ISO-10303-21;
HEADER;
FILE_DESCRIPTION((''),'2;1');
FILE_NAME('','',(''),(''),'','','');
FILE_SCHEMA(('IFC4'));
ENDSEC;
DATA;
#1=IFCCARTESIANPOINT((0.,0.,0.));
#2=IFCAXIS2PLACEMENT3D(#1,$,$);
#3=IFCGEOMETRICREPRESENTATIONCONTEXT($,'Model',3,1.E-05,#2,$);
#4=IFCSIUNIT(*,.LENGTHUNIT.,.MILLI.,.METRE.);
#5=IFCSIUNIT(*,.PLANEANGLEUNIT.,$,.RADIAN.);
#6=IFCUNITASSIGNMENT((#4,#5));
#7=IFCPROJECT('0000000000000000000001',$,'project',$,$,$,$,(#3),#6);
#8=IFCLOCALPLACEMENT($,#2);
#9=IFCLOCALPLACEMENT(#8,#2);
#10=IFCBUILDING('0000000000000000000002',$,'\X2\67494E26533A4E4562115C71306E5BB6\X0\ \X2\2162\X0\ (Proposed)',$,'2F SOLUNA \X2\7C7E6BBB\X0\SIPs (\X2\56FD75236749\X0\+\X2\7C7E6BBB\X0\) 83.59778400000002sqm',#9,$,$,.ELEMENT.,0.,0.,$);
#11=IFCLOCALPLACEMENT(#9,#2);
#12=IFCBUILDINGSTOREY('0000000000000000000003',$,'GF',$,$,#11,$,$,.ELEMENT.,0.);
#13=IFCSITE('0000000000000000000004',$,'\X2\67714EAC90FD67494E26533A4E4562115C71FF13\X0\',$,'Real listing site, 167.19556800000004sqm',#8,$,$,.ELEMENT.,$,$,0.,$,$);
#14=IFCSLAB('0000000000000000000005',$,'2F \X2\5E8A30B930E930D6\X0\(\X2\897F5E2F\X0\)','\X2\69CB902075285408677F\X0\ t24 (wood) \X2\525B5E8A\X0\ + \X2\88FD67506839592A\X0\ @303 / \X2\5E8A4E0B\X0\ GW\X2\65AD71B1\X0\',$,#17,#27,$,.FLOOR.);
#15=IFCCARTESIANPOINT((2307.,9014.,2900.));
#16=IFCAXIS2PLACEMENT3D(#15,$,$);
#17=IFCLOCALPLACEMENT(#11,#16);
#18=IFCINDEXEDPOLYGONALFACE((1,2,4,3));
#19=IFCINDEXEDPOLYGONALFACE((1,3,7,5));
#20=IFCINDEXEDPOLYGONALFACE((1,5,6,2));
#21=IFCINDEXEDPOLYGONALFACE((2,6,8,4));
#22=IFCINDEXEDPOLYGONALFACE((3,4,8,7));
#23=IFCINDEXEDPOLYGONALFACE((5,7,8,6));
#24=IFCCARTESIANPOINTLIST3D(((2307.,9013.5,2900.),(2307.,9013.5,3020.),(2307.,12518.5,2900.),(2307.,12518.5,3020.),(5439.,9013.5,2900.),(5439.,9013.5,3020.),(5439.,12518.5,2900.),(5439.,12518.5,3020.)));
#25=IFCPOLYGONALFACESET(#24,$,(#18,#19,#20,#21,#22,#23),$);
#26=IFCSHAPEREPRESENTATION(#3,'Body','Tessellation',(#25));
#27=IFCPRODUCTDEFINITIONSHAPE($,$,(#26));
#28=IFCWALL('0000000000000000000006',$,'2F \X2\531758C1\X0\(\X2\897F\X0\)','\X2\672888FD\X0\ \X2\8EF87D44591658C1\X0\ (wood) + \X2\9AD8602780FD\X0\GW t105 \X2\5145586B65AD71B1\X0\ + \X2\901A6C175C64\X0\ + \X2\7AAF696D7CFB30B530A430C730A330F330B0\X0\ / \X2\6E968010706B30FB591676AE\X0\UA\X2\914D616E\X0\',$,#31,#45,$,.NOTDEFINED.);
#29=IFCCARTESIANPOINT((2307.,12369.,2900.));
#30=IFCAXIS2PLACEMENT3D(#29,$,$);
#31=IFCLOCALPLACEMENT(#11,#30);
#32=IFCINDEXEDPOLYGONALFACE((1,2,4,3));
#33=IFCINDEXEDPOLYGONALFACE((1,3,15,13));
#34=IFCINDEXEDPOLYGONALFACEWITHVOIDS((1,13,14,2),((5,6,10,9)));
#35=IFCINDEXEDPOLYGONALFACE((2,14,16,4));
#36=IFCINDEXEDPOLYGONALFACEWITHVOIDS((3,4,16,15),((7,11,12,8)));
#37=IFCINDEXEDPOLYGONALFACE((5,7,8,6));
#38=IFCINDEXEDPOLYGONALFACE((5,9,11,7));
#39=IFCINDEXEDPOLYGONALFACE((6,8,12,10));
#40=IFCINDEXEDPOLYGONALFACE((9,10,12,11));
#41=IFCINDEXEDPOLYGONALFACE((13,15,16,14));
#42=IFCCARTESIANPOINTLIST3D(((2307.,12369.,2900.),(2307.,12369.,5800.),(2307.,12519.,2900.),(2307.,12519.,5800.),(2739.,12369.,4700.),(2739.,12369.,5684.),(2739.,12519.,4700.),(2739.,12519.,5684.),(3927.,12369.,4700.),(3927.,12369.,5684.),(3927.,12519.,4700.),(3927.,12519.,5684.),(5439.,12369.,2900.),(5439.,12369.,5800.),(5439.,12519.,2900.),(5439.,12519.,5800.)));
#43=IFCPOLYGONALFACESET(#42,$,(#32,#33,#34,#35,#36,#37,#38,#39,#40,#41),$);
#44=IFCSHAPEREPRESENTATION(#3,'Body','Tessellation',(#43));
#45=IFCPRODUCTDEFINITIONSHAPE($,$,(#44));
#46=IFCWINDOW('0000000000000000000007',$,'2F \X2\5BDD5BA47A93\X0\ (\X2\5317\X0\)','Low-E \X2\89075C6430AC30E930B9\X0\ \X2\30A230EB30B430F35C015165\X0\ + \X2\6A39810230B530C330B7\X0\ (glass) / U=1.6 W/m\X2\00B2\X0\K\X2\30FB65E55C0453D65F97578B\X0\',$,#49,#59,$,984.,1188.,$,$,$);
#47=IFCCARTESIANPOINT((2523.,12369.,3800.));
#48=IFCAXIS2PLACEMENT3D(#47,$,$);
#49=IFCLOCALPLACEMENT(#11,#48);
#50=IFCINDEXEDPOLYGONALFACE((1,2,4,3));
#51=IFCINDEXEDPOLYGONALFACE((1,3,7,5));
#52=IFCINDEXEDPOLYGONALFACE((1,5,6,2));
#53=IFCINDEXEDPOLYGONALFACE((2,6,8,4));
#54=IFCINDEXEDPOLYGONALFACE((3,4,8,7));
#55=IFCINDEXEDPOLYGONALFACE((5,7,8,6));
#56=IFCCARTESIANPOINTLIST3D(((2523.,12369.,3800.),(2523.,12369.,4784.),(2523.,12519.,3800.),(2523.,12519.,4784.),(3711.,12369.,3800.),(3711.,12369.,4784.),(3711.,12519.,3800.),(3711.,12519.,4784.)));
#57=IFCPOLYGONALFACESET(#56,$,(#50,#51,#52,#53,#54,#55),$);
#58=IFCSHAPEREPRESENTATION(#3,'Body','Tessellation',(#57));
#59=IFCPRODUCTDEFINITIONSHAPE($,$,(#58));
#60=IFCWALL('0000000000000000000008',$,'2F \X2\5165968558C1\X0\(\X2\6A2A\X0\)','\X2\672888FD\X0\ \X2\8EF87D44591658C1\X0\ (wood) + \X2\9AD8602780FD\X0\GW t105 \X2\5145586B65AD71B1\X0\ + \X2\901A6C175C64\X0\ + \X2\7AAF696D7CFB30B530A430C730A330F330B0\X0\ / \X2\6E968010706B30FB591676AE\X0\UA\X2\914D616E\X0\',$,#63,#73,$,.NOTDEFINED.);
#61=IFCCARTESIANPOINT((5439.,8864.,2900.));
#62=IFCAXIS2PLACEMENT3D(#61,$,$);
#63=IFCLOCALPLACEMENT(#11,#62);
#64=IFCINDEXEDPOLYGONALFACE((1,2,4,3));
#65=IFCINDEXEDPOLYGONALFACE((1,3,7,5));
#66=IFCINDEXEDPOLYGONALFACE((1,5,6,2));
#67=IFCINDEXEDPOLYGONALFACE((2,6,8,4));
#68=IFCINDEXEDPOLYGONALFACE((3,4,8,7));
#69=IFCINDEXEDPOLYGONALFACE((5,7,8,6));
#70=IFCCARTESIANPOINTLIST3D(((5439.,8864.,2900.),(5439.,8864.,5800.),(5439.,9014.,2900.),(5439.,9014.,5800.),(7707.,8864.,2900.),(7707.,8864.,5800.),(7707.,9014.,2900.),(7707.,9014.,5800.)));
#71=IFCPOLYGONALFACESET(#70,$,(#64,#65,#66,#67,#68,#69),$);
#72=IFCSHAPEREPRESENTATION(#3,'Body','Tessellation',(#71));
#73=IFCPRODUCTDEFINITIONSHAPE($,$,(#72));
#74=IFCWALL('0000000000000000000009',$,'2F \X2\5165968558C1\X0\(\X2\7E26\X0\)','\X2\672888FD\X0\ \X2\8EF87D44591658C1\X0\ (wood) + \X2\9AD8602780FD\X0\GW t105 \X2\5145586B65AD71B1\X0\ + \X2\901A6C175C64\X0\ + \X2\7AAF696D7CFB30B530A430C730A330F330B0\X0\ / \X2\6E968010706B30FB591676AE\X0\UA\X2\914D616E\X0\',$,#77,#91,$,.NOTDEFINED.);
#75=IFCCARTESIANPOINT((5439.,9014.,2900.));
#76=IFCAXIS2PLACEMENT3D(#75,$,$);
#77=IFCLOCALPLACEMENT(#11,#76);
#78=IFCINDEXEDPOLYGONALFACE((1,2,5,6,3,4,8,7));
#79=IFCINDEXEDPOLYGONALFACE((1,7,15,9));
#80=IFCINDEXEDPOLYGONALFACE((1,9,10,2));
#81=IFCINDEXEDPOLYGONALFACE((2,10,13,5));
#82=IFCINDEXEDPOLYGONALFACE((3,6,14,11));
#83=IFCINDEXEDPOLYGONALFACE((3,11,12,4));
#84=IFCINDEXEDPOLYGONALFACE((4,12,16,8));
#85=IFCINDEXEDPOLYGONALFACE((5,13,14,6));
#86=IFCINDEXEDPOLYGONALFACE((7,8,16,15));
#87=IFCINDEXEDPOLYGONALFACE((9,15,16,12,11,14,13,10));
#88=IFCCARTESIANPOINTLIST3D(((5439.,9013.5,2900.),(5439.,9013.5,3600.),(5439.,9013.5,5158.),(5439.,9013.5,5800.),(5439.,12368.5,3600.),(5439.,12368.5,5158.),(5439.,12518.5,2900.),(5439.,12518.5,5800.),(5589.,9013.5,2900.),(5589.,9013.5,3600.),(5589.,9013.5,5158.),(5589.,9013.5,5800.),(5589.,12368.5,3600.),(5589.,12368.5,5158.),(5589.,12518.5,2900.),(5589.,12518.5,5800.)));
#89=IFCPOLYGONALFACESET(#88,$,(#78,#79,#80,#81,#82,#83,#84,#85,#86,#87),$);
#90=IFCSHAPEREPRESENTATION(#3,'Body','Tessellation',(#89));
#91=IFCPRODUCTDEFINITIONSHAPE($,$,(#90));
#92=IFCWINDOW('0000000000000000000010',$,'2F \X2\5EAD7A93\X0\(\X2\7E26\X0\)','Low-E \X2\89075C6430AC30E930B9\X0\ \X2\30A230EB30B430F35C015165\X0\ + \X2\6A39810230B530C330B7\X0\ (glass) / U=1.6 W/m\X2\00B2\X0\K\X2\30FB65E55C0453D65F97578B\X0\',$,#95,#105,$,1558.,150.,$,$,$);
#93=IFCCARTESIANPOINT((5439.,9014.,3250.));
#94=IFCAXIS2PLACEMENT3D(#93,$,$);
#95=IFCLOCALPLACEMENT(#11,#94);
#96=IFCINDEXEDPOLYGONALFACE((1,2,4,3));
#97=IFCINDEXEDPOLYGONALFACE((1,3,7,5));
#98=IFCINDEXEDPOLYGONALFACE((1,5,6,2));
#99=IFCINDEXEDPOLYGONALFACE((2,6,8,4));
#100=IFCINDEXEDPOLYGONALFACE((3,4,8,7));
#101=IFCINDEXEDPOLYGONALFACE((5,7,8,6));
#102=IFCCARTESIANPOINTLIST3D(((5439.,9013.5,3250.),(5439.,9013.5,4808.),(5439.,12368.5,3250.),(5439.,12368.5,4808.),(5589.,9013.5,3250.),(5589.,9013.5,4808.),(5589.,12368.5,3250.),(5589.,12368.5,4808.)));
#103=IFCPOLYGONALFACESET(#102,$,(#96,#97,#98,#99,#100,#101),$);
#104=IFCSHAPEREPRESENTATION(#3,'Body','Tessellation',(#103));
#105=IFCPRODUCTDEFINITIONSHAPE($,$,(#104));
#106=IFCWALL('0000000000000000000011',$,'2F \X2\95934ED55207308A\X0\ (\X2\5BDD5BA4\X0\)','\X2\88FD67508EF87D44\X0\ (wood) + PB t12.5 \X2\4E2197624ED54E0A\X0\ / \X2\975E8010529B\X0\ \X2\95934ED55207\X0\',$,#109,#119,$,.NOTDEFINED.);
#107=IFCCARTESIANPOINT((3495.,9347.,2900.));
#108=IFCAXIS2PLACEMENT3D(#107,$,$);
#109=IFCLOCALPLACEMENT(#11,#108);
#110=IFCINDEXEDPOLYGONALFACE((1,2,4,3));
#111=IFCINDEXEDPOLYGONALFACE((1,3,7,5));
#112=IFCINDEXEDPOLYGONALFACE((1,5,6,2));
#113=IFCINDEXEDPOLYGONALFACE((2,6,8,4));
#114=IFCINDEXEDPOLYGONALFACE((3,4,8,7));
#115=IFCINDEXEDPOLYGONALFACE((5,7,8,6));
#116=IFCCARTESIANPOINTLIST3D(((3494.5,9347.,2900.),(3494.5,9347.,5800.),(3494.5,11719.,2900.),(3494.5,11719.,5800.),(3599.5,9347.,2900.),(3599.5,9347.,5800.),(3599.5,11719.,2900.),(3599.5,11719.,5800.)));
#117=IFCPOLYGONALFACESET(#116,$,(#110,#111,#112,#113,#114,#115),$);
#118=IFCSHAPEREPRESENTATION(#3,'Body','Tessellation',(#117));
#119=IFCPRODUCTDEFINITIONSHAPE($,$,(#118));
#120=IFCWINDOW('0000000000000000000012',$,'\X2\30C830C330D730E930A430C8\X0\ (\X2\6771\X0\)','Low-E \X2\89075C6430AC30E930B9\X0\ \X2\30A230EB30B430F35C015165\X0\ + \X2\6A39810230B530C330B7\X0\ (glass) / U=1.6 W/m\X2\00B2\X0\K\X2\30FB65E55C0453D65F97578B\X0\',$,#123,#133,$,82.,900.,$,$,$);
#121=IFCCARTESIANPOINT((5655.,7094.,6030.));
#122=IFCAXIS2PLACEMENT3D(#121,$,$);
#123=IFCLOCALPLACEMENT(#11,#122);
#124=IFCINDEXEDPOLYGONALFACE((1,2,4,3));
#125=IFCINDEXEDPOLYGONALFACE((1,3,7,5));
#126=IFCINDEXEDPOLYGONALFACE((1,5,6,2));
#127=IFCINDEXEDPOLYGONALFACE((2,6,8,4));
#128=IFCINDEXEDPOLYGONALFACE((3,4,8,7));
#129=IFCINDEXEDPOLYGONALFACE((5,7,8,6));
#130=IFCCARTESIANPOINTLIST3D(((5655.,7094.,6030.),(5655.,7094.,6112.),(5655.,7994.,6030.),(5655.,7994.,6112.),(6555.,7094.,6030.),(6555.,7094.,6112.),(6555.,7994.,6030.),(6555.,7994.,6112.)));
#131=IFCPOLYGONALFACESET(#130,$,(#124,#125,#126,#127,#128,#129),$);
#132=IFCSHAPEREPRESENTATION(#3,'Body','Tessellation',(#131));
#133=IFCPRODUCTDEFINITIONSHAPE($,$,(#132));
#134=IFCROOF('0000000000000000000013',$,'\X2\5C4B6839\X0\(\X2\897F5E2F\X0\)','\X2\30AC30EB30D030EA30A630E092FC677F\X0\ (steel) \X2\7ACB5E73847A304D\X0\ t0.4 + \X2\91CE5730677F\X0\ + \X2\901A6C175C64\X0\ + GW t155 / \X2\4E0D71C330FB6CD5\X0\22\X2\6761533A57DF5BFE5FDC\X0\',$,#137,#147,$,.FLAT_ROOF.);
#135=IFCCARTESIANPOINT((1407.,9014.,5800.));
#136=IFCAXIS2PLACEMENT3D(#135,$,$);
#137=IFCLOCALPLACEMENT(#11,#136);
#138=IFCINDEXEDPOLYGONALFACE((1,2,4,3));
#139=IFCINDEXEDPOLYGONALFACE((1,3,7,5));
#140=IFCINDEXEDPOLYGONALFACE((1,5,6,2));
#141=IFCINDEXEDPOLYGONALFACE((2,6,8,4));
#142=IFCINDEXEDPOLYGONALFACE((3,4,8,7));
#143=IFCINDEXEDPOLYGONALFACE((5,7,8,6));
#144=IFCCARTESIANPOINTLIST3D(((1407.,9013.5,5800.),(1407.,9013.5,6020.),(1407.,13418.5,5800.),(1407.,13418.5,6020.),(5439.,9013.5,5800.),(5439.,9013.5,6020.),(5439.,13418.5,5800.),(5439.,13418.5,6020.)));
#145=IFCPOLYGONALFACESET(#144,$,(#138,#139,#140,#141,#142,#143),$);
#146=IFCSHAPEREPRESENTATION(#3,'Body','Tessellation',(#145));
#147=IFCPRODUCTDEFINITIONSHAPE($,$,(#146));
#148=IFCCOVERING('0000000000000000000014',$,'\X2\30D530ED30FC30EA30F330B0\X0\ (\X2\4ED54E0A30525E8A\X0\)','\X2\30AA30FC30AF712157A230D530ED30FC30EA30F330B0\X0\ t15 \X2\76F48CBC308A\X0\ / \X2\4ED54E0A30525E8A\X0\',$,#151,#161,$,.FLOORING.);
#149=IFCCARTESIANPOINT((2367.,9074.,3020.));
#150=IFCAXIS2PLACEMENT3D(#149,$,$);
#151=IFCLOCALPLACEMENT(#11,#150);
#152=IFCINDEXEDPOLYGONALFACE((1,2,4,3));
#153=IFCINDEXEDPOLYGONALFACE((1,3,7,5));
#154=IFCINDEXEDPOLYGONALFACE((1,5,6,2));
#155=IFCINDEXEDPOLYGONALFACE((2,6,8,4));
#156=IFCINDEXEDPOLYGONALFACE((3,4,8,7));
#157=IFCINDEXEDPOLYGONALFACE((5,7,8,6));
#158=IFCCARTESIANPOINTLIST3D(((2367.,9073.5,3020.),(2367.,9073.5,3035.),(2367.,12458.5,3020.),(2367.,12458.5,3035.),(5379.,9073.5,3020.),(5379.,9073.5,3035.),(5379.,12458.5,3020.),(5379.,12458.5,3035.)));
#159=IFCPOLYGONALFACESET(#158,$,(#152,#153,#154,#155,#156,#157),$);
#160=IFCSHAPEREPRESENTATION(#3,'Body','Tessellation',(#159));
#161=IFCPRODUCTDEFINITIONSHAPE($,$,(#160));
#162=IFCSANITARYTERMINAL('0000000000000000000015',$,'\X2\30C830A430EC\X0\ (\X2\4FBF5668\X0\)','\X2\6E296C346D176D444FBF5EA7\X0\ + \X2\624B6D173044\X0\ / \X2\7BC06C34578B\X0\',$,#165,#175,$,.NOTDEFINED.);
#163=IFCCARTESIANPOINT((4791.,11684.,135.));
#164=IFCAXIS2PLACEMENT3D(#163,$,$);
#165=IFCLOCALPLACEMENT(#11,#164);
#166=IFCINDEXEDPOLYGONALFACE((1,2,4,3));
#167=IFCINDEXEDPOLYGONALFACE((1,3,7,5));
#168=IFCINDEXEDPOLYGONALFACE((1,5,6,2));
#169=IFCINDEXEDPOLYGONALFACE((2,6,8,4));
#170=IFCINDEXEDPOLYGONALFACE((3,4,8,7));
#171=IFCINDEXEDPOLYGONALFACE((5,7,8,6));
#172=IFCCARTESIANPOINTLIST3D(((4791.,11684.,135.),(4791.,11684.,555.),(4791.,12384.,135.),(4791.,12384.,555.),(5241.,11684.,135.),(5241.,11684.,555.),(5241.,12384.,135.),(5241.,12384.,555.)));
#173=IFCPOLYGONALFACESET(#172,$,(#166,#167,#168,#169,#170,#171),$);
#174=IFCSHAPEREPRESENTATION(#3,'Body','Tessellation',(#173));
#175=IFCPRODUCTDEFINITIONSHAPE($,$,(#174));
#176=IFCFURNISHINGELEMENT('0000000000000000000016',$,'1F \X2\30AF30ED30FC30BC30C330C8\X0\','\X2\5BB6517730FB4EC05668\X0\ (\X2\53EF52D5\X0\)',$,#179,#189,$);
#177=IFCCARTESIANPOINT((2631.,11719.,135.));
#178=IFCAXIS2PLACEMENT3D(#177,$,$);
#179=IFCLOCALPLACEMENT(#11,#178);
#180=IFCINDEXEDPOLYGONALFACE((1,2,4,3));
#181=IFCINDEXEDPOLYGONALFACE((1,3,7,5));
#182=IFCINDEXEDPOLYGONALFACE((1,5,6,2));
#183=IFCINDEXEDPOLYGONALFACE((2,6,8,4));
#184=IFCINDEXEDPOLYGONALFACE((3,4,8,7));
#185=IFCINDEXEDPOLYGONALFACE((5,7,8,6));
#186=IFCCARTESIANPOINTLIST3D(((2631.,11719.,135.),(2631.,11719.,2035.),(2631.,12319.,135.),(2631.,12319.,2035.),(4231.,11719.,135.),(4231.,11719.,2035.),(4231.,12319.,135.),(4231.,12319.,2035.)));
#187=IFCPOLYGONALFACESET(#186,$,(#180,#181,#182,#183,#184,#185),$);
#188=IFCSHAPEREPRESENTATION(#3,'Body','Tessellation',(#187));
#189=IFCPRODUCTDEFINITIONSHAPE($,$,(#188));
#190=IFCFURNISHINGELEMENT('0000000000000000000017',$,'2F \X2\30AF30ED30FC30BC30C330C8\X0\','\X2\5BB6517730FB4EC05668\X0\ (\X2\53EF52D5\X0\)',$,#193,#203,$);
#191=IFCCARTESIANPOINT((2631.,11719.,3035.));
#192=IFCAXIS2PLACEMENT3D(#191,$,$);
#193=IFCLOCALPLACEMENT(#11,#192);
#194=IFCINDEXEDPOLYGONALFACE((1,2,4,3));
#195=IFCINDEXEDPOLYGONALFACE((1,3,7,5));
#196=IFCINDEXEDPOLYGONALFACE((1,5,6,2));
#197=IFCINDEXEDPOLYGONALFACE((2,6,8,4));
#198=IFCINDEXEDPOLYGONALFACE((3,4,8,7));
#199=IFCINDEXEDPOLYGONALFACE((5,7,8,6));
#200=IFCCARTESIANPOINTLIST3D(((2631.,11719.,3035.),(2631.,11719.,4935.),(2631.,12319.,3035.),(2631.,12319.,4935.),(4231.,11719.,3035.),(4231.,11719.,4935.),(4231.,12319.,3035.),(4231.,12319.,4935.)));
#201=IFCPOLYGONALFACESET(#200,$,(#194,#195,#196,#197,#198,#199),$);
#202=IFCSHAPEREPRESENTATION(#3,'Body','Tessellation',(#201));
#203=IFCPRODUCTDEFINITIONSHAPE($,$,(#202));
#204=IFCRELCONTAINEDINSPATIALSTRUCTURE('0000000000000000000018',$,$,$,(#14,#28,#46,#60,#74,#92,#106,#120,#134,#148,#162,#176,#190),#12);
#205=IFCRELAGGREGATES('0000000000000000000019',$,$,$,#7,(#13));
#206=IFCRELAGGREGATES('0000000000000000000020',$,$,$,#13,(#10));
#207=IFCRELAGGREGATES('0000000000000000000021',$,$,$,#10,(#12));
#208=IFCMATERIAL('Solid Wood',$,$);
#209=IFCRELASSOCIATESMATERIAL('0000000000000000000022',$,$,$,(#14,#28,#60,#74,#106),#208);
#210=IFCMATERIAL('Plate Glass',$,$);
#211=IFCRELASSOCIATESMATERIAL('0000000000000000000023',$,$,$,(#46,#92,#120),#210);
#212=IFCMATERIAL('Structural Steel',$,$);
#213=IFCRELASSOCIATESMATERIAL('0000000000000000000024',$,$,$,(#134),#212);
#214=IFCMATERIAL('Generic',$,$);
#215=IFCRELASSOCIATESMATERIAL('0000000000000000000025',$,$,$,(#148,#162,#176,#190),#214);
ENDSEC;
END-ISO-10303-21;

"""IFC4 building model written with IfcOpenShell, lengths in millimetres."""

from ifc_helpers import new_model, si_unit, frame, frame_2d, origin, place, context, project, spatial, rectangle, extrude, material, element, fill, save


model = new_model("IFC4")

# Units and contexts
model_context = context("Model", 3, precision=1e-05, world=origin())
ifc_project = project(units=[si_unit("LENGTHUNIT", "METRE", prefix="MILLI"), si_unit("PLANEANGLEUNIT", "RADIAN")], contexts=[model_context])

# Site, building, storey
site_placement = place(None, origin())
site = spatial("IfcSite", under=ifc_project, at=site_placement, Name="東京都杉並区久我山３", ObjectType="Real listing site, 167.19556800000004sqm", CompositionType="ELEMENT", RefElevation=0.0)
building_placement = place(site_placement, origin())
building = spatial("IfcBuilding", under=site, at=building_placement, Name="杉並区久我山の家 Ⅲ (Proposed)", ObjectType="2F SOLUNA 籾殻SIPs (国産杉+籾殻) 83.59778400000002sqm", CompositionType="ELEMENT", ElevationOfRefHeight=0.0, ElevationOfTerrain=0.0)
storey_placement = place(building_placement, origin())
storey = spatial("IfcBuildingStorey", under=building, at=storey_placement, Name="GF", CompositionType="ELEMENT", Elevation=0.0)

# Slab
ifc_material_1 = material(Name="Solid Wood")
slab_placement = place(storey_placement, frame((2307.0, 9014.0, 2900.0)))
element("IfcSlab", 1, at=slab_placement, inside=storey, material=ifc_material_1, Name="2F 床スラブ(西帯)", Description="構造用合板 t24 (wood) 剛床 + 製材根太 @303 / 床下 GW断熱", PredefinedType="FLOOR", context=model_context, shape_type="SweptSolid", body=[
    extrude(rectangle(XDim=3132.0, YDim=3505.0, at=frame_2d((1566.0, 1752.0))), frame((2307.0, 9014.0, 2900.0)), (0.0, 0.0, 1.0), 120.0),
])

# Wall, opening, window
wall_1_placement = place(storey_placement, frame((2307.0, 12369.0, 2900.0)))
wall_1 = element("IfcWall", 2, at=wall_1_placement, inside=storey, material=ifc_material_1, Name="2F 北壁(西)", Description="木製 軸組外壁 (wood) + 高性能GW t105 充填断熱 + 通気層 + 窯業系サイディング / 準耐火・外皮UA配慮", PredefinedType="NOTDEFINED", context=model_context, shape_type="SweptSolid", body=[
    extrude(rectangle(XDim=3132.0, YDim=150.0, at=frame_2d((1566.0, 75.0))), frame((2307.0, 12369.0, 2900.0)), (0.0, 0.0, 1.0), 2900.0),
])
opening_1_placement = place(storey_placement, frame((2523.0, 12369.0, 3800.0)))
opening_1 = element("IfcOpeningElement", 3, at=opening_1_placement, cuts=wall_1, PredefinedType="NOTDEFINED", context=model_context, shape_type="SweptSolid", body=[
    extrude(rectangle(XDim=1188.0, YDim=150.0, at=frame_2d((594.0, 75.0))), frame((2523.0, 12369.0, 3800.0)), (0.0, 0.0, 1.0), 984.0),
])
ifc_material_2 = material(Name="Plate Glass")
window_1_placement = place(storey_placement, frame((2523.0, 12369.0, 3800.0)))
window_1 = element("IfcWindow", 4, at=window_1_placement, inside=storey, material=ifc_material_2, Name="2F 寝室窓 (北)", Description="Low-E 複層ガラス アルゴン封入 + 樹脂サッシ (glass) / U=1.6 W/m²K・日射取得型", OverallHeight=984.0, OverallWidth=1188.0, context=model_context, shape_type="SweptSolid", body=[
    extrude(rectangle(XDim=1188.0, YDim=150.0, at=frame_2d((594.0, 75.0))), frame((2523.0, 12369.0, 3800.0)), (0.0, 0.0, 1.0), 984.0),
])
fill(opening_1, window_1)

# Wall
wall_2_placement = place(storey_placement, frame((5439.0, 8864.0, 2900.0)))
element("IfcWall", 5, at=wall_2_placement, inside=storey, material=ifc_material_1, Name="2F 入隅壁(横)", Description="木製 軸組外壁 (wood) + 高性能GW t105 充填断熱 + 通気層 + 窯業系サイディング / 準耐火・外皮UA配慮", PredefinedType="NOTDEFINED", context=model_context, shape_type="SweptSolid", body=[
    extrude(rectangle(XDim=2268.0, YDim=150.0, at=frame_2d((1134.0, 75.0))), frame((5439.0, 8864.0, 2900.0)), (0.0, 0.0, 1.0), 2900.0),
])

# Wall, opening, window
wall_3_placement = place(storey_placement, frame((5439.0, 9014.0, 2900.0)))
wall_3 = element("IfcWall", 6, at=wall_3_placement, inside=storey, material=ifc_material_1, Name="2F 入隅壁(縦)", Description="木製 軸組外壁 (wood) + 高性能GW t105 充填断熱 + 通気層 + 窯業系サイディング / 準耐火・外皮UA配慮", PredefinedType="NOTDEFINED", context=model_context, shape_type="SweptSolid", body=[
    extrude(rectangle(XDim=150.0, YDim=3505.0, at=frame_2d((75.0, 1752.0))), frame((5439.0, 9014.0, 2900.0)), (0.0, 0.0, 1.0), 2900.0),
])
opening_2_placement = place(storey_placement, frame((5439.0, 9014.0, 3250.0)))
opening_2 = element("IfcOpeningElement", 7, at=opening_2_placement, cuts=wall_3, PredefinedType="NOTDEFINED", context=model_context, shape_type="SweptSolid", body=[
    extrude(rectangle(XDim=150.0, YDim=3355.0, at=frame_2d((75.0, 1677.0))), frame((5439.0, 9014.0, 3250.0)), (0.0, 0.0, 1.0), 1558.0),
])
window_2_placement = place(storey_placement, frame((5439.0, 9014.0, 3250.0)))
window_2 = element("IfcWindow", 8, at=window_2_placement, inside=storey, material=ifc_material_2, Name="2F 庭窓(縦)", Description="Low-E 複層ガラス アルゴン封入 + 樹脂サッシ (glass) / U=1.6 W/m²K・日射取得型", OverallHeight=1558.0, OverallWidth=150.0, context=model_context, shape_type="SweptSolid", body=[
    extrude(rectangle(XDim=150.0, YDim=3355.0, at=frame_2d((75.0, 1677.0))), frame((5439.0, 9014.0, 3250.0)), (0.0, 0.0, 1.0), 1558.0),
])
fill(opening_2, window_2)

# Wall
wall_4_placement = place(storey_placement, frame((3495.0, 9347.0, 2900.0)))
element("IfcWall", 9, at=wall_4_placement, inside=storey, material=ifc_material_1, Name="2F 間仕切り (寝室)", Description="製材軸組 (wood) + PB t12.5 両面仕上 / 非耐力 間仕切", PredefinedType="NOTDEFINED", context=model_context, shape_type="SweptSolid", body=[
    extrude(rectangle(XDim=105.0, YDim=2372.0, at=frame_2d((52.0, 1186.0))), frame((3495.0, 9347.0, 2900.0)), (0.0, 0.0, 1.0), 2900.0),
])

# Window
window_3_placement = place(storey_placement, frame((5655.0, 7094.0, 6030.0)))
element("IfcWindow", 10, at=window_3_placement, inside=storey, material=ifc_material_2, Name="トップライト (東)", Description="Low-E 複層ガラス アルゴン封入 + 樹脂サッシ (glass) / U=1.6 W/m²K・日射取得型", OverallHeight=82.0, OverallWidth=900.0, context=model_context, shape_type="SweptSolid", body=[
    extrude(rectangle(XDim=900.0, YDim=900.0, at=frame_2d((450.0, 450.0))), frame((5655.0, 7094.0, 6030.0)), (0.0, 0.0, 1.0), 82.0),
])

# Roof
ifc_material_3 = material(Name="Structural Steel")
for number, where, name in (
    (11, (1407.0, 9014.0, 5800.0), "屋根(西帯)"),
):
    element("IfcRoof", number, at=place(storey_placement, frame(where)), inside=storey, material=ifc_material_3, Name=name, Description="ガルバリウム鋼板 (steel) 立平葺き t0.4 + 野地板 + 通気層 + GW t155 / 不燃・法22条区域対応", PredefinedType="FLAT_ROOF", context=model_context, shape_type="SweptSolid", body=[
        extrude(rectangle(XDim=4032.0, YDim=4405.0, at=frame_2d((2016.0, 2202.0))), frame((1407.0, 9014.0, 5800.0)), (0.0, 0.0, 1.0), 220.0),
    ])

# Covering
ifc_material_4 = material(Name="Generic")
covering_placement = place(storey_placement, frame((2367.0, 9074.0, 3020.0)))
element("IfcCovering", 12, at=covering_placement, inside=storey, material=ifc_material_4, Name="フローリング (仕上げ床)", Description="オーク無垢フローリング t15 直貼り / 仕上げ床", PredefinedType="FLOORING", context=model_context, shape_type="SweptSolid", body=[
    extrude(rectangle(XDim=3012.0, YDim=3385.0, at=frame_2d((1506.0, 1692.0))), frame((2367.0, 9074.0, 3020.0)), (0.0, 0.0, 1.0), 15.0),
])

# Sanitary terminal
sanitary_terminal_placement = place(storey_placement, frame((4791.0, 11684.0, 135.0)))
element("IfcSanitaryTerminal", 13, at=sanitary_terminal_placement, inside=storey, material=ifc_material_4, Name="トイレ (便器)", Description="温水洗浄便座 + 手洗い / 節水型", PredefinedType="NOTDEFINED", context=model_context, shape_type="SweptSolid", body=[
    extrude(rectangle(XDim=450.0, YDim=700.0, at=frame_2d((225.0, 350.0))), frame((4791.0, 11684.0, 135.0)), (0.0, 0.0, 1.0), 420.0),
])

# Furnishing elements
furnishing_1_placement = place(storey_placement, frame((2631.0, 11719.0, 135.0)))
element("IfcFurnishingElement", 14, at=furnishing_1_placement, inside=storey, material=ifc_material_4, Name="1F クローゼット", Description="家具・什器 (可動)", context=model_context, shape_type="SweptSolid", body=[
    extrude(rectangle(XDim=1600.0, YDim=600.0, at=frame_2d((800.0, 300.0))), frame((2631.0, 11719.0, 135.0)), (0.0, 0.0, 1.0), 1900.0),
])
furnishing_2_placement = place(storey_placement, frame((2631.0, 11719.0, 3035.0)))
element("IfcFurnishingElement", 15, at=furnishing_2_placement, inside=storey, material=ifc_material_4, Name="2F クローゼット", Description="家具・什器 (可動)", context=model_context, shape_type="SweptSolid", body=[
    extrude(rectangle(XDim=1600.0, YDim=600.0, at=frame_2d((800.0, 300.0))), frame((2631.0, 11719.0, 3035.0)), (0.0, 0.0, 1.0), 1900.0),
])

save(model, "model.ifc")
